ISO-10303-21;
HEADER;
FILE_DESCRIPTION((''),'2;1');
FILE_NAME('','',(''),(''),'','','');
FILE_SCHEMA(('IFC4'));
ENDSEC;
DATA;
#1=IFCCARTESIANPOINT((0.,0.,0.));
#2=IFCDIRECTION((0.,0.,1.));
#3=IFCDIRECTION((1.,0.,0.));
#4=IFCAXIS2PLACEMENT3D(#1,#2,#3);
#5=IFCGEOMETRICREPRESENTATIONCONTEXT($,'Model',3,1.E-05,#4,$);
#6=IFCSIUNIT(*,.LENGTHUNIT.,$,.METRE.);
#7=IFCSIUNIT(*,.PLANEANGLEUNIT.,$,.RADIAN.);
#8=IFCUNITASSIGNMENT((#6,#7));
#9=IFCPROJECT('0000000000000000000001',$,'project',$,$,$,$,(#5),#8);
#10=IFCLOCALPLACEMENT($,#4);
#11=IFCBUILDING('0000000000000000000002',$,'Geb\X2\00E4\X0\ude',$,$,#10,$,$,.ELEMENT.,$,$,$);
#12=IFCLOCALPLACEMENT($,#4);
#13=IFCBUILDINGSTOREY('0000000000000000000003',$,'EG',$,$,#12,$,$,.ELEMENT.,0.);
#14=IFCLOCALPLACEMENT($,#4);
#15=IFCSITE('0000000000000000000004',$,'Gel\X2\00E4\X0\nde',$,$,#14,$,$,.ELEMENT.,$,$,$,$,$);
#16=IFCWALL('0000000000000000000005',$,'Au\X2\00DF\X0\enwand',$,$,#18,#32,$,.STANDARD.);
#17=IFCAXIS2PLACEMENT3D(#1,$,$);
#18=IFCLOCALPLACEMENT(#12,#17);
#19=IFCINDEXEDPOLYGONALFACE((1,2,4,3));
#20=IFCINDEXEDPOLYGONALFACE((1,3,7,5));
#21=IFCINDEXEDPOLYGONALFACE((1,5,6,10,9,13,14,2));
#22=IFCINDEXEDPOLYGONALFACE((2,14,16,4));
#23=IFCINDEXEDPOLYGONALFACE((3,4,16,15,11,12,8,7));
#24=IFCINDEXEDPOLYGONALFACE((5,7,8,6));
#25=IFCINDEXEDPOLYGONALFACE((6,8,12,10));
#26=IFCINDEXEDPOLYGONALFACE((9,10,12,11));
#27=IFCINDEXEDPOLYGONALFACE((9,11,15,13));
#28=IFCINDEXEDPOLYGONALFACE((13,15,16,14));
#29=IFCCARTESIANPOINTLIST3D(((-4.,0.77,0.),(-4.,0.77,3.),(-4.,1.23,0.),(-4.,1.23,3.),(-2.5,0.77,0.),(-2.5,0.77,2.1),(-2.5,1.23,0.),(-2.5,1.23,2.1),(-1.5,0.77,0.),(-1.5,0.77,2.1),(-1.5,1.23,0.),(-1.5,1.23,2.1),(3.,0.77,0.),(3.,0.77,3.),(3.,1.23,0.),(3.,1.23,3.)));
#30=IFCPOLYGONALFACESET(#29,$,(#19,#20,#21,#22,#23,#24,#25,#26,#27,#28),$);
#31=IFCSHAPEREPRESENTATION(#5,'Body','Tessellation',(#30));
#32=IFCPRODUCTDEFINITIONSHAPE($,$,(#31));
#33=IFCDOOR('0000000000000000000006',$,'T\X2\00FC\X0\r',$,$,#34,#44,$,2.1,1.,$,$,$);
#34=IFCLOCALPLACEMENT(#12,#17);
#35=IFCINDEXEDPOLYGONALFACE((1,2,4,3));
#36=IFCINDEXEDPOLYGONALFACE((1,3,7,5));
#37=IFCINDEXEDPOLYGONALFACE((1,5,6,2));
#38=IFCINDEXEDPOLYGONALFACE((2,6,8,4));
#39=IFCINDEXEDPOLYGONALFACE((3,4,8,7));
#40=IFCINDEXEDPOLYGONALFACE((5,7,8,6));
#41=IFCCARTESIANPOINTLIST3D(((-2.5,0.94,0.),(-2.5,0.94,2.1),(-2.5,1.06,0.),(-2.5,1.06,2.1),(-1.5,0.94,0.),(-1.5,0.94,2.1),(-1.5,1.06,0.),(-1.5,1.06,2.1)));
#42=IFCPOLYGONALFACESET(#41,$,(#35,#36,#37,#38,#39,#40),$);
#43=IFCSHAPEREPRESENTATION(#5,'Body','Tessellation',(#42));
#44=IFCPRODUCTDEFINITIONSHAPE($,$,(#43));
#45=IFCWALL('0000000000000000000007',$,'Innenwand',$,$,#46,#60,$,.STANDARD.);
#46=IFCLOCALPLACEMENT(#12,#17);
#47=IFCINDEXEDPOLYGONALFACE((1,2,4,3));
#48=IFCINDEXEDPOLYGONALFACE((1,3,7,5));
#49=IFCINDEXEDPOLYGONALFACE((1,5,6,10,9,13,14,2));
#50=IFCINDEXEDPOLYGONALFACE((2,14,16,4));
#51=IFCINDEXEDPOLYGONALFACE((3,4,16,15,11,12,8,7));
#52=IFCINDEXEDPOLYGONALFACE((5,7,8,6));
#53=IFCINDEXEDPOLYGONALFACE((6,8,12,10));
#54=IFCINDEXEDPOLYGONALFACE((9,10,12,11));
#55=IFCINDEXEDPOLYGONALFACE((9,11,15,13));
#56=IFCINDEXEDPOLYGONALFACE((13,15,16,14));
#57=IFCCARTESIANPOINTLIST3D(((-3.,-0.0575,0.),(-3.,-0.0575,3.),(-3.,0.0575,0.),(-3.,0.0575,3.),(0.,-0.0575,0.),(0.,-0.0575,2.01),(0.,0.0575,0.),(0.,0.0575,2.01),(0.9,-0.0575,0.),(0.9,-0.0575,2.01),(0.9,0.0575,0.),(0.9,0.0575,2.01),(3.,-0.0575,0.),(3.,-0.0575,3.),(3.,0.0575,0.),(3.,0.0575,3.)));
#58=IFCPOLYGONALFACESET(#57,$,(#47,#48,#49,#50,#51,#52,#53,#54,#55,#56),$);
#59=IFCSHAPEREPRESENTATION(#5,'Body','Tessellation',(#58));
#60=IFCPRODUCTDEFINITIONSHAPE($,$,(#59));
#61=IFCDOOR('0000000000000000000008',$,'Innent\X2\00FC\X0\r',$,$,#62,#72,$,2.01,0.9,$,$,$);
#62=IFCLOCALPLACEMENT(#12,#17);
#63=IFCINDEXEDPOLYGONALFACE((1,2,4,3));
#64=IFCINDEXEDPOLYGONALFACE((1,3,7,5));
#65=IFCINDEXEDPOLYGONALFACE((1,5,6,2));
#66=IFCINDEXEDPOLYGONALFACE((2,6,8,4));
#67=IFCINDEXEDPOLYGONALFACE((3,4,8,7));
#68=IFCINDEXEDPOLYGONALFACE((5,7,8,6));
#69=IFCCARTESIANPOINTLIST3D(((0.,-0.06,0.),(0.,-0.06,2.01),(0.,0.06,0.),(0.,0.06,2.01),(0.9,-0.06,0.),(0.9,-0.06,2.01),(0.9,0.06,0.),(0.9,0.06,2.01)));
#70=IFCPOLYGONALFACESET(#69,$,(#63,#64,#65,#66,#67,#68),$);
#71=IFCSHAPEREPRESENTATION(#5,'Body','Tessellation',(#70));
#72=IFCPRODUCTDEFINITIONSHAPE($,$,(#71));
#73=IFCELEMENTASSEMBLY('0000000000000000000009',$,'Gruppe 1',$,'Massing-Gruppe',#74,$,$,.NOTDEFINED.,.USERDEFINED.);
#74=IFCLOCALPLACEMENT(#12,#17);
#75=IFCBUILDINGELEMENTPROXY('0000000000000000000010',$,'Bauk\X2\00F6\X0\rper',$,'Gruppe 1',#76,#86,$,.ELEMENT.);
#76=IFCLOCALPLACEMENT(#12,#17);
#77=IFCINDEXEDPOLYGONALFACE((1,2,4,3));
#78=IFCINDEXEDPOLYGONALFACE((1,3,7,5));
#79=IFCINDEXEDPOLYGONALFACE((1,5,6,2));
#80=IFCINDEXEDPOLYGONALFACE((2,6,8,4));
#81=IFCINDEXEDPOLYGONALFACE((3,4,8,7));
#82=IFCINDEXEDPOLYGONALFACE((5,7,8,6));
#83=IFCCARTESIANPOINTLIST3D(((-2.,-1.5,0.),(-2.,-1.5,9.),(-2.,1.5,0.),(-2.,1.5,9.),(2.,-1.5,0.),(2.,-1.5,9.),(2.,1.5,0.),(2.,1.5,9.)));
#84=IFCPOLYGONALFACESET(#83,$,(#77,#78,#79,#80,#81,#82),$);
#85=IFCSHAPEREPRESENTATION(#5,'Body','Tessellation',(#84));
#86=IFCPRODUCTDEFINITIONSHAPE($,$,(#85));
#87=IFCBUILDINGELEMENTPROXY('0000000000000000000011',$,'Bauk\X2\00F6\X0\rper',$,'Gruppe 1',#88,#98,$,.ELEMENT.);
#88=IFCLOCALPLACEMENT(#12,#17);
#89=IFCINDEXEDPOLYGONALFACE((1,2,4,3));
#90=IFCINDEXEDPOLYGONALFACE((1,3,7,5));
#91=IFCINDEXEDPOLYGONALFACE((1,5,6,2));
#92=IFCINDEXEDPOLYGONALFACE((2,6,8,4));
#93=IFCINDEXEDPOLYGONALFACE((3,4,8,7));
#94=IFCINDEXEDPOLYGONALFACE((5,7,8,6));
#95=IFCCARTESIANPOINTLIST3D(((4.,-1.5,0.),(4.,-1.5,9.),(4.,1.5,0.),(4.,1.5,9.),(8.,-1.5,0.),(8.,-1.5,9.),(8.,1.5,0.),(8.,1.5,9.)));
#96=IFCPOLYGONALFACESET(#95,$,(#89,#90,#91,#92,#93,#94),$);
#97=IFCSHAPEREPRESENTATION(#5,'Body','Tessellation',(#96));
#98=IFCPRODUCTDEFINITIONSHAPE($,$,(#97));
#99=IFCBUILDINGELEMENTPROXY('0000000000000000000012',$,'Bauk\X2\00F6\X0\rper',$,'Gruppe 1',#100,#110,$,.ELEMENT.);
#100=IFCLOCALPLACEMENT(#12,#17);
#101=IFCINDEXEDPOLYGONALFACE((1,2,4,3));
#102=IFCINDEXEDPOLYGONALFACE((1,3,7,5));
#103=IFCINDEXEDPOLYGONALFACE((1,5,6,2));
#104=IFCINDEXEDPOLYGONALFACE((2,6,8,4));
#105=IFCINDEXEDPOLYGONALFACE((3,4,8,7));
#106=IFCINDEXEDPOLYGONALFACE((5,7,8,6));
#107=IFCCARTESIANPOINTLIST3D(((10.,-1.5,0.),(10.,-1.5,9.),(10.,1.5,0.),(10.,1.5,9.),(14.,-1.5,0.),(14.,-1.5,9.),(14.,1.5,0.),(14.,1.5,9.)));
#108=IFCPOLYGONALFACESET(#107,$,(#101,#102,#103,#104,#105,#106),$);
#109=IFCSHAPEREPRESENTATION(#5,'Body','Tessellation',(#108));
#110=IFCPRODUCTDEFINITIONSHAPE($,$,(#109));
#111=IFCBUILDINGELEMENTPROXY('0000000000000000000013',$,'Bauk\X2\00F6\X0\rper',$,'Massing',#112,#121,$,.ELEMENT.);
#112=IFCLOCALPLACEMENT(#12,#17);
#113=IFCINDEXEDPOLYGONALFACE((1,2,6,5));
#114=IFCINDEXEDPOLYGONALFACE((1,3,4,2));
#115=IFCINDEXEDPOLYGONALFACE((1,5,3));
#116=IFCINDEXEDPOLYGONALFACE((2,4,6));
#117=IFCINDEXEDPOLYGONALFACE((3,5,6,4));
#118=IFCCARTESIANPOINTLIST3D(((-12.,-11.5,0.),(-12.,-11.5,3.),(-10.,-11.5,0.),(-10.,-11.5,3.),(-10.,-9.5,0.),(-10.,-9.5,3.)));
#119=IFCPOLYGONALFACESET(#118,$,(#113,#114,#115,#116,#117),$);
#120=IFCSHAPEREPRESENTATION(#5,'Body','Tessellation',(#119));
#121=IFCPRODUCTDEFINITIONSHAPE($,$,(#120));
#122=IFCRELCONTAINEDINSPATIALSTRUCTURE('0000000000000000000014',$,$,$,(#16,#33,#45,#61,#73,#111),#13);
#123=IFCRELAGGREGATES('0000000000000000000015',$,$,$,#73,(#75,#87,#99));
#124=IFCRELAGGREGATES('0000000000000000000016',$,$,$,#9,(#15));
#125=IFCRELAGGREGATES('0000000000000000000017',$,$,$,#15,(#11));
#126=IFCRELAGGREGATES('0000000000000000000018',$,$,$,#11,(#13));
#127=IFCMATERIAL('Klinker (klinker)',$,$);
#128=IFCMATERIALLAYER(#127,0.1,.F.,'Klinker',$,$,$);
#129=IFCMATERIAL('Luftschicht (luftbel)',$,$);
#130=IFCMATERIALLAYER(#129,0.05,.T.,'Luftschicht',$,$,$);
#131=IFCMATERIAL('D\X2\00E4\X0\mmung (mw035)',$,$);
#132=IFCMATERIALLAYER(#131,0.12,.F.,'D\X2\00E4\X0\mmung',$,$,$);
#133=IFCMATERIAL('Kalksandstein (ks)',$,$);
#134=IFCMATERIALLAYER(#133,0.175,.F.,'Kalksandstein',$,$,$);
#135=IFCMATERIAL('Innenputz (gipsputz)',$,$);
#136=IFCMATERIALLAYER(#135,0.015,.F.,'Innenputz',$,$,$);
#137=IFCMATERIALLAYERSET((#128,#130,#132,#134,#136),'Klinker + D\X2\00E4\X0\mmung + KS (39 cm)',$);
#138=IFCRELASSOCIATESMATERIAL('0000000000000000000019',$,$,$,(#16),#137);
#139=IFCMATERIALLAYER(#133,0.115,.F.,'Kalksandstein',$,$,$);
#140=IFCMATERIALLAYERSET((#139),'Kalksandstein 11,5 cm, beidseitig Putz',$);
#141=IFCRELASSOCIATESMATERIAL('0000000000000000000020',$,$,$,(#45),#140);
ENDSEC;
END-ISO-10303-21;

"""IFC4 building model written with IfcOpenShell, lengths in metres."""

from ifc_helpers import new_model, si_unit, frame, origin_with_axes, origin_2d, place, context, project, spatial, polyline, rectangle, outline, extrude, material, layer, layer_set, element, fill, aggregate, save


model = new_model("IFC4")

# Units and contexts
model_context = context("Model", 3, precision=1e-05, world=origin_with_axes())
ifc_project = project(units=[si_unit("LENGTHUNIT", "METRE"), si_unit("PLANEANGLEUNIT", "RADIAN")], contexts=[model_context])

# Site, building, storey
site_placement = place(None, origin_with_axes())
site = spatial("IfcSite", under=ifc_project, at=site_placement, Name="Gelände", CompositionType="ELEMENT")
building_placement = place(None, origin_with_axes())
building = spatial("IfcBuilding", under=site, at=building_placement, Name="Gebäude", CompositionType="ELEMENT")
storey_placement = place(None, origin_with_axes())
storey = spatial("IfcBuildingStorey", under=building, at=storey_placement, Name="EG", CompositionType="ELEMENT", Elevation=0.0)

# Walls, openings, doors
ifc_material_1 = material(Name="Klinker (klinker)")
ifc_layer_1 = layer(ifc_material_1, 0.1, ventilated=False, Name="Klinker")
ifc_material_2 = material(Name="Luftschicht (luftbel)")
ifc_layer_2 = layer(ifc_material_2, 0.05, ventilated=True, Name="Luftschicht")
ifc_material_3 = material(Name="Dämmung (mw035)")
ifc_layer_3 = layer(ifc_material_3, 0.12, ventilated=False, Name="Dämmung")
ifc_material_4 = material(Name="Kalksandstein (ks)")
ifc_layer_4 = layer(ifc_material_4, 0.175, ventilated=False, Name="Kalksandstein")
ifc_material_5 = material(Name="Innenputz (gipsputz)")
ifc_layer_5 = layer(ifc_material_5, 0.015, ventilated=False, Name="Innenputz")
ifc_layer_set_1 = layer_set([ifc_layer_1, ifc_layer_2, ifc_layer_3, ifc_layer_4, ifc_layer_5], Name="Klinker + Dämmung + KS (39 cm)")
wall_1_placement = place(None, frame((-0.5, 1.0, 0.0), z_axis=(0.0, 0.0, 1.0), x_axis=(1.0, 0.0, 0.0)))
wall_1 = element("IfcWall", 1, at=wall_1_placement, inside=storey, material=ifc_layer_set_1, Name="Außenwand", PredefinedType="STANDARD", context=model_context, shape_type="SweptSolid", body=[
    extrude(rectangle(XDim=7.0, YDim=0.46, at=origin_2d()), origin_with_axes(), (0.0, 0.0, 1.0), 3.0),
])
opening_1_placement = place(wall_1_placement, frame((-1.5, 0.0, 0.0), z_axis=(0.0, 0.0, 1.0), x_axis=(1.0, 0.0, 0.0)))
opening_1 = element("IfcOpeningElement", 2, at=opening_1_placement, cuts=wall_1, PredefinedType="OPENING", context=model_context, shape_type="SweptSolid", body=[
    extrude(rectangle(XDim=1.0, YDim=0.5, at=origin_2d()), origin_with_axes(), (0.0, 0.0, 1.0), 2.1),
])
door_1_placement = place(opening_1_placement, origin_with_axes())
door_1 = element("IfcDoor", 3, at=door_1_placement, inside=storey, Name="Tür", OverallHeight=2.1, OverallWidth=1.0, context=model_context, shape_type="SweptSolid", body=[
    extrude(rectangle(XDim=1.0, YDim=0.12, at=origin_2d()), origin_with_axes(), (0.0, 0.0, 1.0), 2.1),
])
fill(opening_1, door_1)
ifc_layer_6 = layer(ifc_material_4, 0.115, ventilated=False, Name="Kalksandstein")
ifc_layer_set_2 = layer_set([ifc_layer_6], Name="Kalksandstein 11,5 cm, beidseitig Putz")
wall_2_placement = place(None, origin_with_axes())
wall_2 = element("IfcWall", 4, at=wall_2_placement, inside=storey, material=ifc_layer_set_2, Name="Innenwand", PredefinedType="STANDARD", context=model_context, shape_type="SweptSolid", body=[
    extrude(rectangle(XDim=6.0, YDim=0.115, at=origin_2d()), origin_with_axes(), (0.0, 0.0, 1.0), 3.0),
])
opening_2_placement = place(wall_2_placement, frame((0.45, 0.0, 0.0), z_axis=(0.0, 0.0, 1.0), x_axis=(1.0, 0.0, 0.0)))
opening_2 = element("IfcOpeningElement", 5, at=opening_2_placement, cuts=wall_2, PredefinedType="OPENING", context=model_context, shape_type="SweptSolid", body=[
    extrude(rectangle(XDim=0.9, YDim=0.155, at=origin_2d()), origin_with_axes(), (0.0, 0.0, 1.0), 2.01),
])
door_2_placement = place(opening_2_placement, origin_with_axes())
door_2 = element("IfcDoor", 6, at=door_2_placement, inside=storey, Name="Innentür", OverallHeight=2.01, OverallWidth=0.9, context=model_context, shape_type="SweptSolid", body=[
    extrude(rectangle(XDim=0.9, YDim=0.12, at=origin_2d()), origin_with_axes(), (0.0, 0.0, 1.0), 2.01),
])
fill(opening_2, door_2)

# Element assembly, building element proxies
assembly_placement = place(None, origin_with_axes())
assembly = element("IfcElementAssembly", 7, at=assembly_placement, inside=storey, Name="Gruppe 1", ObjectType="Massing-Gruppe", AssemblyPlace="NOTDEFINED", PredefinedType="USERDEFINED")
proxy_1_placement = place(None, origin_with_axes())
proxy_1 = element("IfcBuildingElementProxy", 8, at=proxy_1_placement, Name="Baukörper", ObjectType="Gruppe 1", PredefinedType="ELEMENT", context=model_context, shape_type="SweptSolid", body=[
    extrude(outline(polyline([(-2.0, -1.5), (2.0, -1.5), (2.0, 1.5), (-2.0, 1.5), (-2.0, -1.5)])), origin_with_axes(), (0.0, 0.0, 1.0), 9.0),
])
proxy_2_placement = place(None, origin_with_axes())
proxy_2 = element("IfcBuildingElementProxy", 9, at=proxy_2_placement, Name="Baukörper", ObjectType="Gruppe 1", PredefinedType="ELEMENT", context=model_context, shape_type="SweptSolid", body=[
    extrude(outline(polyline([(4.0, -1.5), (8.0, -1.5), (8.0, 1.5), (4.0, 1.5), (4.0, -1.5)])), origin_with_axes(), (0.0, 0.0, 1.0), 9.0),
])
proxy_3_placement = place(None, origin_with_axes())
proxy_3 = element("IfcBuildingElementProxy", 10, at=proxy_3_placement, Name="Baukörper", ObjectType="Gruppe 1", PredefinedType="ELEMENT", context=model_context, shape_type="SweptSolid", body=[
    extrude(outline(polyline([(10.0, -1.5), (14.0, -1.5), (14.0, 1.5), (10.0, 1.5), (10.0, -1.5)])), origin_with_axes(), (0.0, 0.0, 1.0), 9.0),
])
aggregate(assembly, [proxy_1, proxy_2, proxy_3])

# Building element proxy
proxy_4_placement = place(None, origin_with_axes())
element("IfcBuildingElementProxy", 11, at=proxy_4_placement, inside=storey, Name="Baukörper", ObjectType="Massing", PredefinedType="ELEMENT", context=model_context, shape_type="SweptSolid", body=[
    extrude(outline(polyline([(-12.0, -11.5), (-10.0, -11.5), (-10.0, -9.5), (-12.0, -11.5)])), origin_with_axes(), (0.0, 0.0, 1.0), 3.0),
])

save(model, "model.ifc")
